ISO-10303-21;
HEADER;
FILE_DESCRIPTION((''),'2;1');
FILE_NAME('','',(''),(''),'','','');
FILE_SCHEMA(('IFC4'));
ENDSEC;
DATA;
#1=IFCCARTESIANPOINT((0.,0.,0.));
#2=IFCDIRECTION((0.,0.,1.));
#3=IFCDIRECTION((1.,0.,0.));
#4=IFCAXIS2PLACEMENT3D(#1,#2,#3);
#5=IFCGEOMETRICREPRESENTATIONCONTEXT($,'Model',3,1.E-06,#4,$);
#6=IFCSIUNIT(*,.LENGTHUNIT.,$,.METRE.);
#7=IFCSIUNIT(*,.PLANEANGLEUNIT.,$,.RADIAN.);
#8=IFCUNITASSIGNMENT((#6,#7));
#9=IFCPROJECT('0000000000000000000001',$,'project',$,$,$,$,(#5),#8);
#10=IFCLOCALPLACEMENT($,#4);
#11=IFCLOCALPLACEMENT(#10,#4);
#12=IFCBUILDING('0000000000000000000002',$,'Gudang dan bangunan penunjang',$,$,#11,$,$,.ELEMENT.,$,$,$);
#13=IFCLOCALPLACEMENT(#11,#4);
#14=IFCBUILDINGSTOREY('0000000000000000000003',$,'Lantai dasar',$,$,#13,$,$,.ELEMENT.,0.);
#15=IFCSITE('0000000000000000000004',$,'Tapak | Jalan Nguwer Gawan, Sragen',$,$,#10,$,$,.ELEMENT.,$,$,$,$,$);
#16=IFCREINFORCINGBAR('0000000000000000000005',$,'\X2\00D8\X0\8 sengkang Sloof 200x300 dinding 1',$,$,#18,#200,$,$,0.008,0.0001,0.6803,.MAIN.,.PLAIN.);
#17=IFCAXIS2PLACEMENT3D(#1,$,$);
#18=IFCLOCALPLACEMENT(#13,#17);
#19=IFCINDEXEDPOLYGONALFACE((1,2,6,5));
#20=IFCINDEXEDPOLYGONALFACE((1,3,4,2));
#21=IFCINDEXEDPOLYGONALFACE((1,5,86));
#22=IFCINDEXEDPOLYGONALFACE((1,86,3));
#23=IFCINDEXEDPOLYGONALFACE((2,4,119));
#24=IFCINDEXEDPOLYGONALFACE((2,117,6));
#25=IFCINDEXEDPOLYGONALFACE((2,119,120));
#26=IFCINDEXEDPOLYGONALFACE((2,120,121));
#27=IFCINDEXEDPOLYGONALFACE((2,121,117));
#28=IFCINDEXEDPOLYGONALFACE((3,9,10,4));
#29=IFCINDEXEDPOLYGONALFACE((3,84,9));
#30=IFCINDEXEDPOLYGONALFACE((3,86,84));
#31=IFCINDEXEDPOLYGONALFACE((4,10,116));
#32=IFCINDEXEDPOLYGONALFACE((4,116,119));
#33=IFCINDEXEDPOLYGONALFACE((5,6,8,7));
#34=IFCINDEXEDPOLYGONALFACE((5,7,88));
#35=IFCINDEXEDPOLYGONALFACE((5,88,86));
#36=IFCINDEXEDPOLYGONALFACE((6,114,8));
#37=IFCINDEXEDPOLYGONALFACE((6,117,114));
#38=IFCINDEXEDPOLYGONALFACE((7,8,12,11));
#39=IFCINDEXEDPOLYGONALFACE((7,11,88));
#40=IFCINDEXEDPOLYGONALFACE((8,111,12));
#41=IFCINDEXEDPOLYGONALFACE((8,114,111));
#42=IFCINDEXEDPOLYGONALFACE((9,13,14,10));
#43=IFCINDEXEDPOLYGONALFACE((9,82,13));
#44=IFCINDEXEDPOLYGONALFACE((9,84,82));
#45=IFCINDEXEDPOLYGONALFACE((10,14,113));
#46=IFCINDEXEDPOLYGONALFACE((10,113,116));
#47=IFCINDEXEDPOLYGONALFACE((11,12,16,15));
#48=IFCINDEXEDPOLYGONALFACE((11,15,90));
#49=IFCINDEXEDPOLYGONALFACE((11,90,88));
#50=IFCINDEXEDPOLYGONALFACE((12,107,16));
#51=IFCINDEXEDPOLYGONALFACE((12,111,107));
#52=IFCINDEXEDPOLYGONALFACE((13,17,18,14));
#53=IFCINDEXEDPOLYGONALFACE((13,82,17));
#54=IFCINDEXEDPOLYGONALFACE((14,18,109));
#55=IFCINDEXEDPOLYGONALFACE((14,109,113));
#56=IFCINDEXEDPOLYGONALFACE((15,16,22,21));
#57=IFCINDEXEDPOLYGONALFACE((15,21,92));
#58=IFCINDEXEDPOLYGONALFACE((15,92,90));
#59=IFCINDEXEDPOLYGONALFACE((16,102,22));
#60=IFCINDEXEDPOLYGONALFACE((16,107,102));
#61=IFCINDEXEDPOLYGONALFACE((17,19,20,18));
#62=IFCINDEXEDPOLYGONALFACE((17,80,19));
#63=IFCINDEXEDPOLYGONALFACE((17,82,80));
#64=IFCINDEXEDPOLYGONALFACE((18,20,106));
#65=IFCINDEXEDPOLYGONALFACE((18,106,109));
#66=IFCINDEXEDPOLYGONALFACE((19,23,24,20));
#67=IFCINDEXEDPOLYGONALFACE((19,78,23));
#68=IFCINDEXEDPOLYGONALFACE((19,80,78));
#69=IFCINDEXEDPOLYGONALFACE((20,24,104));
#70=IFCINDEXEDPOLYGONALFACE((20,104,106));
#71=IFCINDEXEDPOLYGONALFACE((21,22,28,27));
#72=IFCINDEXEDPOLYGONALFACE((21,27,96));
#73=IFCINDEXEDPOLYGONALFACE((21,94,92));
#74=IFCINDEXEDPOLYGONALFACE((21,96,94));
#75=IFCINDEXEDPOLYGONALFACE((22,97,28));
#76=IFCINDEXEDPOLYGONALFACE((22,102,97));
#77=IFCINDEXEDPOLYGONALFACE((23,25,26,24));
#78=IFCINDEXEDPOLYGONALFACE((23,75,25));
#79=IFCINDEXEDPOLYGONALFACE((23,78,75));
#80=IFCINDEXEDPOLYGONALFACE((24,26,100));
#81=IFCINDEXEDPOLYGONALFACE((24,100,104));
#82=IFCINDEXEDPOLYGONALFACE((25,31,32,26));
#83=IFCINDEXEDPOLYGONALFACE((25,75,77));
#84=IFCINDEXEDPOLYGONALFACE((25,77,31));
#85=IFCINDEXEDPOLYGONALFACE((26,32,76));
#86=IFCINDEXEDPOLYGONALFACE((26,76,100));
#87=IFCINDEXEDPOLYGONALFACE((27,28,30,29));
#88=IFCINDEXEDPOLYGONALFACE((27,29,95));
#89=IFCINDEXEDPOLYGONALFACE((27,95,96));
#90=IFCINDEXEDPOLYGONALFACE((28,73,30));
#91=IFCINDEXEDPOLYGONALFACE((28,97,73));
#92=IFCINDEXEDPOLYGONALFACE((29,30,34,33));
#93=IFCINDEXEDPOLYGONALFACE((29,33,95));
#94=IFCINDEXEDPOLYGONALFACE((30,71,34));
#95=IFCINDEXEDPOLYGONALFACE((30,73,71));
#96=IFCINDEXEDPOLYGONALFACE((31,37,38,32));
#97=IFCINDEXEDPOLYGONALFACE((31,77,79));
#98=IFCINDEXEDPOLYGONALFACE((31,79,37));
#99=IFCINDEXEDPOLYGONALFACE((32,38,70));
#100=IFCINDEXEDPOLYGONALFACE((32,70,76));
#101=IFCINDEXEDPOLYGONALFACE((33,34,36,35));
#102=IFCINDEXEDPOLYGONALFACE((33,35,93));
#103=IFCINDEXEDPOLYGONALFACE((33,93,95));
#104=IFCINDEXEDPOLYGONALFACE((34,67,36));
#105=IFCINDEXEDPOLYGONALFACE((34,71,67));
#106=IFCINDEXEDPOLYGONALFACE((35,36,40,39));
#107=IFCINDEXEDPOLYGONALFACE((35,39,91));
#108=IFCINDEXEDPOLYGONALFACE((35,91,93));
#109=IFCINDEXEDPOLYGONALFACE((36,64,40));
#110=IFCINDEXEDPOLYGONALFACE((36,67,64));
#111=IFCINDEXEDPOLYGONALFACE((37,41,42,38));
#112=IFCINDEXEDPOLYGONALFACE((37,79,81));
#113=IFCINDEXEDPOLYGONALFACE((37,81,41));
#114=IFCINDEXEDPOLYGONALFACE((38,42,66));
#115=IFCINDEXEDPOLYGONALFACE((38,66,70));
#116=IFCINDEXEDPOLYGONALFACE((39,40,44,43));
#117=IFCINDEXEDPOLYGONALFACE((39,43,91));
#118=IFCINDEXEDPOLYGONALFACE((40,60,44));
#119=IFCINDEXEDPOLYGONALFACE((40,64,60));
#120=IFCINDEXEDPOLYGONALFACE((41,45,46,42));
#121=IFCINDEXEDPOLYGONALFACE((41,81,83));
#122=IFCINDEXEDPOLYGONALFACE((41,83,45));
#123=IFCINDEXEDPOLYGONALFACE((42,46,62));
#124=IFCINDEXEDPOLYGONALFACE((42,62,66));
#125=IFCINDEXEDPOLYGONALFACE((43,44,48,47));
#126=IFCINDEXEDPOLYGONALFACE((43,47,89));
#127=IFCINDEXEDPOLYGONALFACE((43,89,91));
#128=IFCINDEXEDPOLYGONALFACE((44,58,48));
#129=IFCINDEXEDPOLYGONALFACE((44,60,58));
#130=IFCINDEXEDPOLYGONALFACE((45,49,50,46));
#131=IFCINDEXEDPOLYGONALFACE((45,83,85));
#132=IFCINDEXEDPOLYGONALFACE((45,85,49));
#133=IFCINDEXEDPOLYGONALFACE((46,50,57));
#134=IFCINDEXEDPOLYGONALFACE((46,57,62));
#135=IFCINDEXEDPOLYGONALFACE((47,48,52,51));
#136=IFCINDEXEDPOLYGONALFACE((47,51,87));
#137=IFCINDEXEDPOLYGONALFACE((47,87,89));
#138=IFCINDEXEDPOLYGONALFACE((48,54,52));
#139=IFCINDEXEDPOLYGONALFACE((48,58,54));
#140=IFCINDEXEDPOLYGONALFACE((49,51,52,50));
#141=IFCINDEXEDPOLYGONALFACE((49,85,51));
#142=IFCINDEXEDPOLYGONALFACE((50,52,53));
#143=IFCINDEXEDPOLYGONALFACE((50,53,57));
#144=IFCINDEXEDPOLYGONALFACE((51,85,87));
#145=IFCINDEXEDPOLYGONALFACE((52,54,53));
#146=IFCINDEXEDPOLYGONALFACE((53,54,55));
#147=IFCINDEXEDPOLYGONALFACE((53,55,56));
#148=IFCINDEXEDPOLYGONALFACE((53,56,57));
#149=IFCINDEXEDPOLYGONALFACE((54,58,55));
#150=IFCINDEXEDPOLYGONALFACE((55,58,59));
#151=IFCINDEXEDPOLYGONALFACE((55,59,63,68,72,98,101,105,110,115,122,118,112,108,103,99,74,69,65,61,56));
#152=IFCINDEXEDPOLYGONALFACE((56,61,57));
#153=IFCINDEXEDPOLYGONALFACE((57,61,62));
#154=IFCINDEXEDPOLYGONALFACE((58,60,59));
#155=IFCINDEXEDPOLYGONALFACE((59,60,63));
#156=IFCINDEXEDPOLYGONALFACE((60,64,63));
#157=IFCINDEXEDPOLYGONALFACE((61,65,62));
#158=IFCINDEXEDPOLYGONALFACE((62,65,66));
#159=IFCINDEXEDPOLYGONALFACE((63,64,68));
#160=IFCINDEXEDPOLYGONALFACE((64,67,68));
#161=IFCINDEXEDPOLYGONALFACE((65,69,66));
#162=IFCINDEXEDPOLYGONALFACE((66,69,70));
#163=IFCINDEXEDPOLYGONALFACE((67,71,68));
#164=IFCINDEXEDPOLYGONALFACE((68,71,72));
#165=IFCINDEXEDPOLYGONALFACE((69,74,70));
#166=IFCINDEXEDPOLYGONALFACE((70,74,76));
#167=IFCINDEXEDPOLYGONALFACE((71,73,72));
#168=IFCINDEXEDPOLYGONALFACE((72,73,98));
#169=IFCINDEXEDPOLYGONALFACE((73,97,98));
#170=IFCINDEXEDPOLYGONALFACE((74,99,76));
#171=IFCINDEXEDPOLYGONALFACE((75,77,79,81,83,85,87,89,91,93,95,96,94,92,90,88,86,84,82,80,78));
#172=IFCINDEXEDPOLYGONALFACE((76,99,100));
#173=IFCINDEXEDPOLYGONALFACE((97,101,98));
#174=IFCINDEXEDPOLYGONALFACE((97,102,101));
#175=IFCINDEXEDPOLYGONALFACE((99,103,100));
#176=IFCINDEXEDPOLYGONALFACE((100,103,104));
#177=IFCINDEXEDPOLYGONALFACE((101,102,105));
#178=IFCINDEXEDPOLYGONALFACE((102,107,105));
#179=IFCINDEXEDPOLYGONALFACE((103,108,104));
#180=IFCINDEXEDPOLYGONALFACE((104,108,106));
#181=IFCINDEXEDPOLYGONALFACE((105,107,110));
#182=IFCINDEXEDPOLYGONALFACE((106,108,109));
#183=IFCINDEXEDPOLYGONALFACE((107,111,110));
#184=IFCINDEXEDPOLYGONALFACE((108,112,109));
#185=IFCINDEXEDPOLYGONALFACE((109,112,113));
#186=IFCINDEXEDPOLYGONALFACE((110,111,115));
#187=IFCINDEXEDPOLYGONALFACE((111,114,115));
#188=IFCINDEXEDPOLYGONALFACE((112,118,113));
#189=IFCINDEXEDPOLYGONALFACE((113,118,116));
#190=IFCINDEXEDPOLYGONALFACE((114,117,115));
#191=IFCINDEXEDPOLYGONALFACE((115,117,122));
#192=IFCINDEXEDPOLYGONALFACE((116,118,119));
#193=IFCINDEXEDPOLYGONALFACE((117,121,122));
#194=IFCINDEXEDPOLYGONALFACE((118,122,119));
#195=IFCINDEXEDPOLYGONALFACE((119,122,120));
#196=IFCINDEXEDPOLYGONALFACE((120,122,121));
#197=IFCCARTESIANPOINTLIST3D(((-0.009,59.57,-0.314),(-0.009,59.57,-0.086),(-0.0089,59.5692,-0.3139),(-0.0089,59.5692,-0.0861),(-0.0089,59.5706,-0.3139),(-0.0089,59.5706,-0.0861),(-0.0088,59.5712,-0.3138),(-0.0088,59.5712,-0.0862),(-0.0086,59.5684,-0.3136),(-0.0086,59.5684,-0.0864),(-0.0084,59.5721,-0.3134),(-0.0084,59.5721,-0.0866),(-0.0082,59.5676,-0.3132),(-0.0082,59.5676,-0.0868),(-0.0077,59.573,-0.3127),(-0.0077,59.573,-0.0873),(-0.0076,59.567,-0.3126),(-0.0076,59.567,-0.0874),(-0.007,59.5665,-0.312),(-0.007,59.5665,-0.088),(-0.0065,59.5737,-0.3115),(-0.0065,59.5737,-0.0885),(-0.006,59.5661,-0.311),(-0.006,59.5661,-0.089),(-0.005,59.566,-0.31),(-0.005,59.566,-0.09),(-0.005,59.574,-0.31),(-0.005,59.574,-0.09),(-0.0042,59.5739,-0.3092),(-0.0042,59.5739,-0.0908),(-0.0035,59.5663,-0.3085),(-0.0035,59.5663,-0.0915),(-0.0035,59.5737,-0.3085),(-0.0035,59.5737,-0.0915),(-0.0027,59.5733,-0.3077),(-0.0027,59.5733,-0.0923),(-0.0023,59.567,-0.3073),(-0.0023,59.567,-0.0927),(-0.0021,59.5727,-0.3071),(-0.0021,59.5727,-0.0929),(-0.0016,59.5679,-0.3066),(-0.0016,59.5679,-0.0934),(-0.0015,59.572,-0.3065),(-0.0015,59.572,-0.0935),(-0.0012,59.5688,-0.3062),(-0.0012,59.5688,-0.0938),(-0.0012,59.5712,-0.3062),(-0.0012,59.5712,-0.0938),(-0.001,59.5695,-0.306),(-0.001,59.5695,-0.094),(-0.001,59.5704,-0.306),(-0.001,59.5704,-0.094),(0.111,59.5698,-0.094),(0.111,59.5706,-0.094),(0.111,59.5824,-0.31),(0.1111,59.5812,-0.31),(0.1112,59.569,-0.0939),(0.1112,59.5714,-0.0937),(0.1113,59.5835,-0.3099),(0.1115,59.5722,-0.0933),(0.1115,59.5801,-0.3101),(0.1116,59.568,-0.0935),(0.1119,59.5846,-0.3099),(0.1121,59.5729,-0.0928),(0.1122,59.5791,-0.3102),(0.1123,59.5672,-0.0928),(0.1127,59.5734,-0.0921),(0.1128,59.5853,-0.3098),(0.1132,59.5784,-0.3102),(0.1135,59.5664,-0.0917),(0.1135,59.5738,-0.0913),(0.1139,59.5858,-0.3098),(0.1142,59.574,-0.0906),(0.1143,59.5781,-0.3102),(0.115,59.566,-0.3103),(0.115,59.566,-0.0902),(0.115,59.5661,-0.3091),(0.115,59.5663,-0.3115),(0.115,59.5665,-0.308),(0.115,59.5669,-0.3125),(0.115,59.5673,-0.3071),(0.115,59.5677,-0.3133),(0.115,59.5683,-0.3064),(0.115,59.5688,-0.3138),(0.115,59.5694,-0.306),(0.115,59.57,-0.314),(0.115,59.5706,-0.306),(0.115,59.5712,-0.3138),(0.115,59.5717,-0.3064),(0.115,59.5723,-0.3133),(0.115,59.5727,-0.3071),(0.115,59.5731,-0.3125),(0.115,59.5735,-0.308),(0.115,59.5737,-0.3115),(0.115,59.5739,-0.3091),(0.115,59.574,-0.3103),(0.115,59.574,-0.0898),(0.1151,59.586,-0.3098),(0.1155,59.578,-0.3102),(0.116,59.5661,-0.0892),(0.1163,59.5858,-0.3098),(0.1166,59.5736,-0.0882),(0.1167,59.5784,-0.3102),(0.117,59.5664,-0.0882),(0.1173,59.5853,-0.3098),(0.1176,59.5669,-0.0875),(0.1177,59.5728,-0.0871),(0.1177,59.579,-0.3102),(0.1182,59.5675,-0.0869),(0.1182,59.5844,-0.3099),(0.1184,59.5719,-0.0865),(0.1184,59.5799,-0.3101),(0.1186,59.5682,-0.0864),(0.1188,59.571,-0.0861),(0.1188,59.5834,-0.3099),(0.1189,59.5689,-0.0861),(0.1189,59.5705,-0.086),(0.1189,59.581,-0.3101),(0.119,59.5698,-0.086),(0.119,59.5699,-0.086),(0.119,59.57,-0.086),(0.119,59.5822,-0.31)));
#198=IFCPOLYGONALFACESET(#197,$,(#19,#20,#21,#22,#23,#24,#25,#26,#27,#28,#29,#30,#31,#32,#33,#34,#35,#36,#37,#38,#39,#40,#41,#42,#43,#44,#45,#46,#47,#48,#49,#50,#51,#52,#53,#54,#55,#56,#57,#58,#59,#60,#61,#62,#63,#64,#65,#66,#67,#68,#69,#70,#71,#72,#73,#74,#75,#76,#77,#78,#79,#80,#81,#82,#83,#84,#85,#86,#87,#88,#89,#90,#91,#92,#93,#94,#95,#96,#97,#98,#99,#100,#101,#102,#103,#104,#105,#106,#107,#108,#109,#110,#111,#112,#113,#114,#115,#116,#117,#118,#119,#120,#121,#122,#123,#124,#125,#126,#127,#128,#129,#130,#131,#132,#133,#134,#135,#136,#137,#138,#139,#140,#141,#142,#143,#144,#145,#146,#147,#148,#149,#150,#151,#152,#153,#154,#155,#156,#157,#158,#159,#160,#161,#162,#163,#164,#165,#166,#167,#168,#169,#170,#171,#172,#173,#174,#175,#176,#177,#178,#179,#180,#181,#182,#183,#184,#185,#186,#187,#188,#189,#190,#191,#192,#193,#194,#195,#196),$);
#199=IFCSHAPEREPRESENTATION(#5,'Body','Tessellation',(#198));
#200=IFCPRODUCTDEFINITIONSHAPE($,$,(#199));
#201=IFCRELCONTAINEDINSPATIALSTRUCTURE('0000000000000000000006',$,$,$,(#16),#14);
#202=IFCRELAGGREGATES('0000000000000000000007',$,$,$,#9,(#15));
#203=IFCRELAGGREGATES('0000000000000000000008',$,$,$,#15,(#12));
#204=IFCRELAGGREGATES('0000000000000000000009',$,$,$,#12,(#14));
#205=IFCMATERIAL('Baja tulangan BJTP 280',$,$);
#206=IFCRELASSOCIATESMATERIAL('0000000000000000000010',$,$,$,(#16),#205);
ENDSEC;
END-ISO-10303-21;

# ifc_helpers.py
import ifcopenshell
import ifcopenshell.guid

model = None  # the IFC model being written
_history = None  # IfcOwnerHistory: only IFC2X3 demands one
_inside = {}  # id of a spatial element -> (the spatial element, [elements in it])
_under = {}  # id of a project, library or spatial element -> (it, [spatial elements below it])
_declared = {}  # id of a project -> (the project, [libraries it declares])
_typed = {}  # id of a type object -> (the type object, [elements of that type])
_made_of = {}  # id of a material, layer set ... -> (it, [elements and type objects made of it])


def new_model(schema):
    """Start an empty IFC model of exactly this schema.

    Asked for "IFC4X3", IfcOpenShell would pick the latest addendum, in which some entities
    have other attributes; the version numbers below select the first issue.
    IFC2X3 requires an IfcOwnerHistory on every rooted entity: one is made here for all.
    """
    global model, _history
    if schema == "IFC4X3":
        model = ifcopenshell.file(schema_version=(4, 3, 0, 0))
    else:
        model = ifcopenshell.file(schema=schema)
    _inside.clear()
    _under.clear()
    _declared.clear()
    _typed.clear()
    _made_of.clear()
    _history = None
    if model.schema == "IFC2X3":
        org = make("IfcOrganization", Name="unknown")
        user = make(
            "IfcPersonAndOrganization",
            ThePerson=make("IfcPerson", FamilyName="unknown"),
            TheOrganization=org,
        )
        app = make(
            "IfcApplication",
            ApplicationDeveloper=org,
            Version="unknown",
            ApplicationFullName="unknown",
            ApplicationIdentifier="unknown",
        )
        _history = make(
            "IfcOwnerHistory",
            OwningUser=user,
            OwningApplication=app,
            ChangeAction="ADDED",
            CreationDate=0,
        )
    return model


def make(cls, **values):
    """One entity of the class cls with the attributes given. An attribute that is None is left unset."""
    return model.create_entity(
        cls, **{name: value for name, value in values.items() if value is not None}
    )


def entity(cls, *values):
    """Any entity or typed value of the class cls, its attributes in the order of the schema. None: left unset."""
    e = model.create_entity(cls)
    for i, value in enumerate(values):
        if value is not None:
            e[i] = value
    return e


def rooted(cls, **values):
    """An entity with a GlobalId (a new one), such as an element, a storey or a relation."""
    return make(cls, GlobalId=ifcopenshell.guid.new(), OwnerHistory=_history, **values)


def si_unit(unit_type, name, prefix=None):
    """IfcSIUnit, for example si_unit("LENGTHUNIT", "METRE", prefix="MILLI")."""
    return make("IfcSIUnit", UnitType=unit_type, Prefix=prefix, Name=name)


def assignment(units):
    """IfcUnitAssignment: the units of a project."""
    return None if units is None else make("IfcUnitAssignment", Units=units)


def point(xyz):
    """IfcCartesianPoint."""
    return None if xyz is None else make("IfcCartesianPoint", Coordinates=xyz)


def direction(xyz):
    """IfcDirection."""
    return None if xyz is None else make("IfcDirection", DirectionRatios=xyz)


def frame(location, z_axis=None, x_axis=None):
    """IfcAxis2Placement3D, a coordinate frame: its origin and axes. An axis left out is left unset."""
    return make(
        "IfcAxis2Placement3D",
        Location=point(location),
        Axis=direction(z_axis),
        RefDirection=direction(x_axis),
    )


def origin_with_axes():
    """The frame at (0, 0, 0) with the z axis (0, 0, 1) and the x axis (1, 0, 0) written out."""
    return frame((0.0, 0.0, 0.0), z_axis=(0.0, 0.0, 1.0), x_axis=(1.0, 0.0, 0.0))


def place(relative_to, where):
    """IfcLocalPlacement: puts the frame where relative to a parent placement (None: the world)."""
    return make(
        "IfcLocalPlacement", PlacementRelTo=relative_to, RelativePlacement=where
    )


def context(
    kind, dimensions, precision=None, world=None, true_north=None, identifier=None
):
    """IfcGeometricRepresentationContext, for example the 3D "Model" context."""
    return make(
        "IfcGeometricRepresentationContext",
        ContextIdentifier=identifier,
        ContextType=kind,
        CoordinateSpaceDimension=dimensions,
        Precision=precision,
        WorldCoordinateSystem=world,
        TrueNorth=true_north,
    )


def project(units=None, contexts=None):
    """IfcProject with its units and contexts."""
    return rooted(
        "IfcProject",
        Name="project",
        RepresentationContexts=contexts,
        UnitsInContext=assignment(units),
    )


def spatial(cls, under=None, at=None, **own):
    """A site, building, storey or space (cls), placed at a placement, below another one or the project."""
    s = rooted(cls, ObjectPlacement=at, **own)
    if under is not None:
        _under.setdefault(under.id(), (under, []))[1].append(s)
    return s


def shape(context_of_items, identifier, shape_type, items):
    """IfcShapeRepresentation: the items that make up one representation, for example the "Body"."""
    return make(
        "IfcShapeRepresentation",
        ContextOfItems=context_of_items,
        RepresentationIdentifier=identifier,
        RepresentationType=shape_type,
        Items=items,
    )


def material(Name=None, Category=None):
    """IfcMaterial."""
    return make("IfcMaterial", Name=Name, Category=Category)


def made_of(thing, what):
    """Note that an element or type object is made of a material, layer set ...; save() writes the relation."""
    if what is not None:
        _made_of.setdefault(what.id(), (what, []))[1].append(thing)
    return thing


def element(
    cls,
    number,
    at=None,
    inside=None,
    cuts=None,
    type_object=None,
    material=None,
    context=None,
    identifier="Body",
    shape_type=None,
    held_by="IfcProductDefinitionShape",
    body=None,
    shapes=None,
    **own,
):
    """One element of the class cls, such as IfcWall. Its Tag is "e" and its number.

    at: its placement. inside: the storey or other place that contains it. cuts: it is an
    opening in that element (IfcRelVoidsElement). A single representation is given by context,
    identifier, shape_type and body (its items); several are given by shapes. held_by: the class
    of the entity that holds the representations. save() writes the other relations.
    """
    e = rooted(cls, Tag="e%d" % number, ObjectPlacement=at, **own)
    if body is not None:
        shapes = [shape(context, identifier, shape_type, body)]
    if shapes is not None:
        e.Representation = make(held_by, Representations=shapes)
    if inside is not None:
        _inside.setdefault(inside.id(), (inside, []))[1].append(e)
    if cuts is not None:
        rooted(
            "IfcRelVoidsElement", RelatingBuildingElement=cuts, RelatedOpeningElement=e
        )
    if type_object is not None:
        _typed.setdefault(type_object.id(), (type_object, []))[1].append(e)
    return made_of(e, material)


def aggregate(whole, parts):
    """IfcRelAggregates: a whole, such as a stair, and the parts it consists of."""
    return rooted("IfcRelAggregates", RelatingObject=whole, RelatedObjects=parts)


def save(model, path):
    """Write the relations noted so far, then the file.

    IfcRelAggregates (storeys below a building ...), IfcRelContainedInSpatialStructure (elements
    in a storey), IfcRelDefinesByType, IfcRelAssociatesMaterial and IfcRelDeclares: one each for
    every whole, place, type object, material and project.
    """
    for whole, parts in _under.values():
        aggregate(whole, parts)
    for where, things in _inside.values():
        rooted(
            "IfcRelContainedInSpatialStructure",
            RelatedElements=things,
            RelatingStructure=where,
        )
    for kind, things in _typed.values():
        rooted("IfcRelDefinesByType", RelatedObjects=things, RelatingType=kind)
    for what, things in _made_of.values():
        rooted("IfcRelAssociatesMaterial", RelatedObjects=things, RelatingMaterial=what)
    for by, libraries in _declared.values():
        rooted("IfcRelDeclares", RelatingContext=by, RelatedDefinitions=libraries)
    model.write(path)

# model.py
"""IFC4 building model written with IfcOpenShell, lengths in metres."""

from ifc_helpers import new_model, entity, si_unit, origin_with_axes, place, context, project, spatial, material, element, save


model = new_model("IFC4")

# Units and contexts
model_context = context("Model", 3, precision=1e-06, world=origin_with_axes())
ifc_project = project(units=[si_unit("LENGTHUNIT", "METRE"), si_unit("PLANEANGLEUNIT", "RADIAN")], contexts=[model_context])

# Site, building, storey
site_placement = place(None, origin_with_axes())
site = spatial("IfcSite", under=ifc_project, at=site_placement, Name="Tapak | Jalan Nguwer Gawan, Sragen", CompositionType="ELEMENT")
building_placement = place(site_placement, origin_with_axes())
building = spatial("IfcBuilding", under=site, at=building_placement, Name="Gudang dan bangunan penunjang", CompositionType="ELEMENT")
storey_placement = place(building_placement, origin_with_axes())
storey = spatial("IfcBuildingStorey", under=building, at=storey_placement, Name="Lantai dasar", CompositionType="ELEMENT", Elevation=0.0)

# Shared definitions
placement = place(None, origin_with_axes())

# Reinforcing bar
ifc_material_1 = material(Name="Baja tulangan BJTP 280")
element("IfcReinforcingBar", 1, at=placement, inside=storey, material=ifc_material_1, Name="Ø8 sengkang Sloof 200x300 dinding 1", BarLength=0.6803, BarSurface="PLAIN", CrossSectionArea=0.0001, NominalDiameter=0.008, PredefinedType="MAIN", context=model_context, shape_type="AdvancedSweptSolid", body=[
    entity("IfcSweptDiskSolid", entity("IfcPolyline", [entity("IfcCartesianPoint", [0.115, 59.57, -0.31]), entity("IfcCartesianPoint", [-0.005, 59.57, -0.31]), entity("IfcCartesianPoint", [-0.005, 59.57, -0.09]), entity("IfcCartesianPoint", [0.115, 59.57, -0.09]), entity("IfcCartesianPoint", [0.115, 59.582, -0.31])]), 0.004),
])

save(model, "model.ifc")
